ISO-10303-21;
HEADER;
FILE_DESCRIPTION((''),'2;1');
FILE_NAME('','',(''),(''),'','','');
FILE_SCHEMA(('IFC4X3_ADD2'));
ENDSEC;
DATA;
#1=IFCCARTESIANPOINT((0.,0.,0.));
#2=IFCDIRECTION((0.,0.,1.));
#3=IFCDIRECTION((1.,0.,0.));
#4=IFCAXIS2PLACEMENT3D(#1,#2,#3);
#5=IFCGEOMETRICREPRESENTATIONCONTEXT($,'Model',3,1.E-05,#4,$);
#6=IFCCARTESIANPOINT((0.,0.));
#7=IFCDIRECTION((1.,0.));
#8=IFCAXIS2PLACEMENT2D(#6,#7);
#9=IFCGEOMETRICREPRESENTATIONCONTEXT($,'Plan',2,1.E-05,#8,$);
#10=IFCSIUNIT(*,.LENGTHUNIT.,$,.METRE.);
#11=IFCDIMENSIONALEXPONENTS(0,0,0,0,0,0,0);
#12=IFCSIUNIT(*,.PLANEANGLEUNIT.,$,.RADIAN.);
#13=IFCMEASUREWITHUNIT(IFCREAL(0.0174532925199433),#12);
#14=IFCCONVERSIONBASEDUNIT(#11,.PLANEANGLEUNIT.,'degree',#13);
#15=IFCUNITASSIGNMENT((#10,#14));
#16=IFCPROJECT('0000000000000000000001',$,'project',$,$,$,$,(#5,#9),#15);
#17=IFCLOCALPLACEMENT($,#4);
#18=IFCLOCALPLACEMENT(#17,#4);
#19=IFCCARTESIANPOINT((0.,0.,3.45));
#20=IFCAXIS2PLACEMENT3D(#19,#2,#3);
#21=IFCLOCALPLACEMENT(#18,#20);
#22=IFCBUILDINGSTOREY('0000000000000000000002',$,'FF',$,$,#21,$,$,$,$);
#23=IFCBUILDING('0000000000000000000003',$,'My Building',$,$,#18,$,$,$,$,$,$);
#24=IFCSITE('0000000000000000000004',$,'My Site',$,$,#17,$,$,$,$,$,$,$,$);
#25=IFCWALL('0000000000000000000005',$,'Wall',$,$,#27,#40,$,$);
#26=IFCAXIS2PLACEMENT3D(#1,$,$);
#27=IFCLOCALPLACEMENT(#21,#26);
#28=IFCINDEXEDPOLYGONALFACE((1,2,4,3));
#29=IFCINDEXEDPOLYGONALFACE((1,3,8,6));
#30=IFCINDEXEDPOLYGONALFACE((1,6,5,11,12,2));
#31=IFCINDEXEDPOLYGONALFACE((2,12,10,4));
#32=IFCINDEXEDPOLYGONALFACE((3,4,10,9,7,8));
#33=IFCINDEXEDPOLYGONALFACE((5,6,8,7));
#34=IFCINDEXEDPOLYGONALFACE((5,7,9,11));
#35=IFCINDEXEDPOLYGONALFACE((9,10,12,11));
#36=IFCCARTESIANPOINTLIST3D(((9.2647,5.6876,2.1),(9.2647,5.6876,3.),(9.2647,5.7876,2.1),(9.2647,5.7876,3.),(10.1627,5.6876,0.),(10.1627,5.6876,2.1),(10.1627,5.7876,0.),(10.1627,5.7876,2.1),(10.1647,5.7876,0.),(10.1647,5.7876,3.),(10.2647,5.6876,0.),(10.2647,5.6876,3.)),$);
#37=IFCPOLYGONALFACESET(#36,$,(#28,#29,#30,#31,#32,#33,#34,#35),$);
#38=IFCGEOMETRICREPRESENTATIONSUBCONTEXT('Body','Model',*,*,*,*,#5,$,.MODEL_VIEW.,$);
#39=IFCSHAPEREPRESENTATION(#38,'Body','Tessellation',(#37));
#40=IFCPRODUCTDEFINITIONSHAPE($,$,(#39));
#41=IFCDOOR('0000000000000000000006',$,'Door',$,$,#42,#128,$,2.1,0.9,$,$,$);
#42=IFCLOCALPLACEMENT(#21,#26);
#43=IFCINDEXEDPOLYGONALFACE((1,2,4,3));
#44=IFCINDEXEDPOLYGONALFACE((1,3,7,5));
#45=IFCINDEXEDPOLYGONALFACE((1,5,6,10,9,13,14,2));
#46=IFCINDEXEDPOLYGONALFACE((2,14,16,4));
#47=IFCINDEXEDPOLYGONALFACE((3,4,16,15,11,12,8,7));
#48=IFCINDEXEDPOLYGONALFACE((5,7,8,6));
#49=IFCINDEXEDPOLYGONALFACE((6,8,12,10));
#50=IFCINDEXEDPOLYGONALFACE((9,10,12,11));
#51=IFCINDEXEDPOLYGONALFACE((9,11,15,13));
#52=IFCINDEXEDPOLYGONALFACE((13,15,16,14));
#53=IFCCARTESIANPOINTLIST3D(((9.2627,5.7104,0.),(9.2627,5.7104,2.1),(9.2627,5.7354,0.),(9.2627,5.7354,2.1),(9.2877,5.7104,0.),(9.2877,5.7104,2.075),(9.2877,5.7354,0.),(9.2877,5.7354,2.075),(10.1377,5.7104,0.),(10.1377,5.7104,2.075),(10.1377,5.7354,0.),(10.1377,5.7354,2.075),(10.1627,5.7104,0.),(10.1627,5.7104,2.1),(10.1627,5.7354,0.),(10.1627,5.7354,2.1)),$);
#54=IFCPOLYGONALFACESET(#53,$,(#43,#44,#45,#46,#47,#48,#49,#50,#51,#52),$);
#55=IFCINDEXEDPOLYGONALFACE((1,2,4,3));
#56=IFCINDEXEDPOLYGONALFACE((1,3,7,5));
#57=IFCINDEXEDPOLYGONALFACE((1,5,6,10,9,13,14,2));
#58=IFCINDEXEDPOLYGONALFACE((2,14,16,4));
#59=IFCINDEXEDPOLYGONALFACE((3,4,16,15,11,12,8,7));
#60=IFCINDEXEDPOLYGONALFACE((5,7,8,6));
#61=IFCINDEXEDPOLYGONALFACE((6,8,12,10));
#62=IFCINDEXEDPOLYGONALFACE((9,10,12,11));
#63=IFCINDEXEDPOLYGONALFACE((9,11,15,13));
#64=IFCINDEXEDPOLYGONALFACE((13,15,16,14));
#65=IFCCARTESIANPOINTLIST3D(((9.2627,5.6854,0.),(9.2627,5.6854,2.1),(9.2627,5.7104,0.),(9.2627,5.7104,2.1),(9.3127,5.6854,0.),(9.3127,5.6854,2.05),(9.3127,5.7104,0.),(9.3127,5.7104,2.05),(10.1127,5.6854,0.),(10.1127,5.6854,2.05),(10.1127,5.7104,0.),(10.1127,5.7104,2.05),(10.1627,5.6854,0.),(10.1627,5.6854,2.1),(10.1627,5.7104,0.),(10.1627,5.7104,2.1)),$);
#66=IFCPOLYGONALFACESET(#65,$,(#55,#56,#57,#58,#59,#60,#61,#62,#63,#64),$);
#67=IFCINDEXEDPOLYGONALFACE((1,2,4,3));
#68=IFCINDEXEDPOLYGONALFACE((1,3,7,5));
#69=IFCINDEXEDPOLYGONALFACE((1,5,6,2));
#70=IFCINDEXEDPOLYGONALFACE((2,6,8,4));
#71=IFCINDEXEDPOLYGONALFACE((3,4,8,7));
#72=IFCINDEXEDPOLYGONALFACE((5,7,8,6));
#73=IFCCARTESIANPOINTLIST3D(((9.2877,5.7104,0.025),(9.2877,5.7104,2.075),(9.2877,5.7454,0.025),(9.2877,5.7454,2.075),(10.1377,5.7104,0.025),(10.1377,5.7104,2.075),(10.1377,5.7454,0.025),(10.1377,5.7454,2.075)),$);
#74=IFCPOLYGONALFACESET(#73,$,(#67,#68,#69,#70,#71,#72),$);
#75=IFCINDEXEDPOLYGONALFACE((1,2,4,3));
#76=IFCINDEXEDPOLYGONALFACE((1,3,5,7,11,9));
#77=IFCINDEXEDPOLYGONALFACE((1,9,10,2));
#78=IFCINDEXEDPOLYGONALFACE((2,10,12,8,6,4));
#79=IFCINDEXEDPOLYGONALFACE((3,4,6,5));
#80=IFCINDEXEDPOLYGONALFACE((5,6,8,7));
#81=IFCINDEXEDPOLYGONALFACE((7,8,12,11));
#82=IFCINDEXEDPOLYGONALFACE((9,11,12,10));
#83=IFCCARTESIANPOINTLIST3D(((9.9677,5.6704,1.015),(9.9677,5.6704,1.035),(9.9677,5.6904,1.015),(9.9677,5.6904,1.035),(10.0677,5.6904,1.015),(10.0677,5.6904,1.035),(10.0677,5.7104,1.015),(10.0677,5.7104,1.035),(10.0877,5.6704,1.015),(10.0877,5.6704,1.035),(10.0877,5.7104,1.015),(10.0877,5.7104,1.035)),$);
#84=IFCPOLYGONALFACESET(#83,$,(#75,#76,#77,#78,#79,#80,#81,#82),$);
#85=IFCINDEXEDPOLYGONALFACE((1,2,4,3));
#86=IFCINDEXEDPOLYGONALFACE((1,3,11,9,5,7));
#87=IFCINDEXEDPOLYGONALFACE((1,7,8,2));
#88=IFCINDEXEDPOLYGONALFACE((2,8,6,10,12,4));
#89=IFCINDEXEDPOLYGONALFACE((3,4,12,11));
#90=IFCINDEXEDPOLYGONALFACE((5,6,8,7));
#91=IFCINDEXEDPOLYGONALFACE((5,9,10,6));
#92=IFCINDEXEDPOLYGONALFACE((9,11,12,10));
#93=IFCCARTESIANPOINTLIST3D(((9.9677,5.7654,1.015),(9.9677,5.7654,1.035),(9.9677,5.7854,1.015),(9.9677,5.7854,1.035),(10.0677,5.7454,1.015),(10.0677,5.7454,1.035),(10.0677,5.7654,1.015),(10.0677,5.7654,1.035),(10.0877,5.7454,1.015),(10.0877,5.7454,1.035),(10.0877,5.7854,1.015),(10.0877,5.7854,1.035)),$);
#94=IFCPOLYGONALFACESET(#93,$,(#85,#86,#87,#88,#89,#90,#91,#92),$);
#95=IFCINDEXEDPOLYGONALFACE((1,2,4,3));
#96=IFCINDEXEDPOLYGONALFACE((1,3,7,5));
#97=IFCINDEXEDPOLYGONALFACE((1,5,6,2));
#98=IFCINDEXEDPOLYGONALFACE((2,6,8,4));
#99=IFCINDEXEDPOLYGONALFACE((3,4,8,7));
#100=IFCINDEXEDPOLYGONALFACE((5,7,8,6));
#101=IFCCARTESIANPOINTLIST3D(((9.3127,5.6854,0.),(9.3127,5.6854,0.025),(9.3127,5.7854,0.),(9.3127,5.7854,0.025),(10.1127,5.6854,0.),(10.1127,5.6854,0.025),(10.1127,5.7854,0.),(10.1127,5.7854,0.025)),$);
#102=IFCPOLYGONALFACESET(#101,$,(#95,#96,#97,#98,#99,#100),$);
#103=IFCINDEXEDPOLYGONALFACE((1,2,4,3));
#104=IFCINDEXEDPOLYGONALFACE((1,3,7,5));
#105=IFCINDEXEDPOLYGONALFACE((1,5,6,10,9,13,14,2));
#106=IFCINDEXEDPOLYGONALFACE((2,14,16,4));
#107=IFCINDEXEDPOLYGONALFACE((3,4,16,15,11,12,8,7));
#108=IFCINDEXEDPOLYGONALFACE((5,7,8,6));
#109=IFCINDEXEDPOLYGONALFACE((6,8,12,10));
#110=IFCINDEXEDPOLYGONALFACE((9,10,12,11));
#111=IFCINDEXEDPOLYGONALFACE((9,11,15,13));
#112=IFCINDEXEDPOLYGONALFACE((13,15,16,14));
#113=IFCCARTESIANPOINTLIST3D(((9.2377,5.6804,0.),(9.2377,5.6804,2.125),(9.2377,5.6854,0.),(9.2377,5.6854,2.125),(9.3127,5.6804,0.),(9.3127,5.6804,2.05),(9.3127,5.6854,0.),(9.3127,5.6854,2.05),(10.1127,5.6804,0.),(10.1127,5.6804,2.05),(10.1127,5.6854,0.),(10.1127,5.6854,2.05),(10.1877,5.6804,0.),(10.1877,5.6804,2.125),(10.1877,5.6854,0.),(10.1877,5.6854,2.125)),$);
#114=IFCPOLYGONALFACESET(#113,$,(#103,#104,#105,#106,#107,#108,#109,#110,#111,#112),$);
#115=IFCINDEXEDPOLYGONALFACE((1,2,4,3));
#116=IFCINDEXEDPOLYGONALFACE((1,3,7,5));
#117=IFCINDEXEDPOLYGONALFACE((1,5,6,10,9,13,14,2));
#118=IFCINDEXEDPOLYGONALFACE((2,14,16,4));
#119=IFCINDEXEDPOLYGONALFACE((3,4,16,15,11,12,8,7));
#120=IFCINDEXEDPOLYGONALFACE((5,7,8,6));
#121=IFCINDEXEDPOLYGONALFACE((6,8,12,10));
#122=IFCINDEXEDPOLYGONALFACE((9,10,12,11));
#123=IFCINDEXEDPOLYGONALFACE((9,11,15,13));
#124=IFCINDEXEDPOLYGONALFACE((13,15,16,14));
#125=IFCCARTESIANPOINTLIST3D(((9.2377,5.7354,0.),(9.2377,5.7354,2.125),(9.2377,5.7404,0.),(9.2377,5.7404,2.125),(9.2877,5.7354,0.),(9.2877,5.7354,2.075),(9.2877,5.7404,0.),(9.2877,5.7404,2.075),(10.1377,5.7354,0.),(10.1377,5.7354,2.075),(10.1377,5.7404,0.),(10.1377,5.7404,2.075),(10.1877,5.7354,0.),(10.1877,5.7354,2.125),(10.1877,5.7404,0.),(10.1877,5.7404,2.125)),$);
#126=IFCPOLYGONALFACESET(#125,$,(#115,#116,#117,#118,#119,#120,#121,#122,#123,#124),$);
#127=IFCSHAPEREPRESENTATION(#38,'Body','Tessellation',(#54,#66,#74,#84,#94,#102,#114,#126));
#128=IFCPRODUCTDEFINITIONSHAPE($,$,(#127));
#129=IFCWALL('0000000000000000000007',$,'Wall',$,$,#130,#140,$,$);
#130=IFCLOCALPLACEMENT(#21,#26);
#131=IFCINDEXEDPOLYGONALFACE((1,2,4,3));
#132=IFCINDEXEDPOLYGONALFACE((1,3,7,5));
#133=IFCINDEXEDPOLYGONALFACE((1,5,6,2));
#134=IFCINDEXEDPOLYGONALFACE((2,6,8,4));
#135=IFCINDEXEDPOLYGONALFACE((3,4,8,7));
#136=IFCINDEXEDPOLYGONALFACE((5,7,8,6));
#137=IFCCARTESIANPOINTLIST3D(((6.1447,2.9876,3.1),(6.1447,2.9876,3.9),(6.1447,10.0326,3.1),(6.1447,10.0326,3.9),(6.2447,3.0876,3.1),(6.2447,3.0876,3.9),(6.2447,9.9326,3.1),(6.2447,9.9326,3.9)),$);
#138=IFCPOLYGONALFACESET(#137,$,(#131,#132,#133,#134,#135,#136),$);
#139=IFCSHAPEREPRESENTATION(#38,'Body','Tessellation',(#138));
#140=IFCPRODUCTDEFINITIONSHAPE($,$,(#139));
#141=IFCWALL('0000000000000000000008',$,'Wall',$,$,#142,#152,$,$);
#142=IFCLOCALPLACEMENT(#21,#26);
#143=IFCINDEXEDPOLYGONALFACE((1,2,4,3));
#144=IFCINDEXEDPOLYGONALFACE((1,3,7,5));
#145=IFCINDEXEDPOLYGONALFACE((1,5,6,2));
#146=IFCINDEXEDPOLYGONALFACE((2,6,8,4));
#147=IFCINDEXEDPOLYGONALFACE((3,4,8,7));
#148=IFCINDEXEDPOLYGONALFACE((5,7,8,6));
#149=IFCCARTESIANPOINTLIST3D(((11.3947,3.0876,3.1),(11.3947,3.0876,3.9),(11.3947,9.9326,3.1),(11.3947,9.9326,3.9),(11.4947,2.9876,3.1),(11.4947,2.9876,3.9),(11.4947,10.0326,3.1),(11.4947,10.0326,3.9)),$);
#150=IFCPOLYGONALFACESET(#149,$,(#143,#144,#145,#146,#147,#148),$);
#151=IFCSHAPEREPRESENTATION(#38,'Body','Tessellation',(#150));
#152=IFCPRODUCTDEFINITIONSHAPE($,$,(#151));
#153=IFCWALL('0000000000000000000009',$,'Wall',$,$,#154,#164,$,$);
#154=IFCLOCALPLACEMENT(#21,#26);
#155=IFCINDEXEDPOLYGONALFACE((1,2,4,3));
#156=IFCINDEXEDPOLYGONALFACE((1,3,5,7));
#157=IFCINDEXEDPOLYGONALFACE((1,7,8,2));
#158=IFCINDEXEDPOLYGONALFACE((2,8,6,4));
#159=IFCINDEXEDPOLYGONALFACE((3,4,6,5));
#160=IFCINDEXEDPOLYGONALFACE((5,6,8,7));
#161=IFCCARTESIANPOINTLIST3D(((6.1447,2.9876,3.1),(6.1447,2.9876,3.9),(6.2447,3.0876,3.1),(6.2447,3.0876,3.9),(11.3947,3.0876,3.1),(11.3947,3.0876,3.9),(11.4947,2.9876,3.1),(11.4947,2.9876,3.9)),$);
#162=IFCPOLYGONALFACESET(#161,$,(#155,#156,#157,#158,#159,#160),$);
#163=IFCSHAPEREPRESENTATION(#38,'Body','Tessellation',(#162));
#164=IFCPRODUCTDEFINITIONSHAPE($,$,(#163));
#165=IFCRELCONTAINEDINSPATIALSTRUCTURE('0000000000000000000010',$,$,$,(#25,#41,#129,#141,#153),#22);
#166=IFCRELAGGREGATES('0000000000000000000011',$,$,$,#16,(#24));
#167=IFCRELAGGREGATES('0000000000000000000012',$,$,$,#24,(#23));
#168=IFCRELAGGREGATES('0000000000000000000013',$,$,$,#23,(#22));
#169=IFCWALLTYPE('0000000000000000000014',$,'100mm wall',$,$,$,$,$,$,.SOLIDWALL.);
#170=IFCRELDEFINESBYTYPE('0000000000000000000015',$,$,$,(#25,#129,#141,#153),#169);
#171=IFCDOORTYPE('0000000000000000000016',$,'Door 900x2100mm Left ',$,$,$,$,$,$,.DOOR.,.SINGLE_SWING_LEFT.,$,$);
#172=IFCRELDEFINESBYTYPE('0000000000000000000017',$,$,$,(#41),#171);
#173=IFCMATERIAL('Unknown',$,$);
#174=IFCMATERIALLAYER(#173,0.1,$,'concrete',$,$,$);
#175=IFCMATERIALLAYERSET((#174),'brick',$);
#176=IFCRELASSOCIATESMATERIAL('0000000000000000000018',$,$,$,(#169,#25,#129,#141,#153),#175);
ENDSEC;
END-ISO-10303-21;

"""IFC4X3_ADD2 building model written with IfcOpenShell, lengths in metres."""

from ifc_helpers import new_model, entity, si_unit, converted_unit, frame, origin_with_axes, origin_2d_with_axis, place, context, subcontext, project, spatial, line, indexed_curve, outline, extrude, shape, source, transform, mapped, material, layer, layer_set, layer_usage, type_object, type_shapes, element, fill, save


model = new_model("IFC4X3_ADD2")

# Units and contexts
model_context = context("Model", 3, precision=1e-05, world=origin_with_axes())
plan_context = context("Plan", 2, precision=1e-05, world=origin_2d_with_axis())
body_context_1 = subcontext(model_context, "Body", "Model", "MODEL_VIEW")
body_context_2 = subcontext(plan_context, "Body", "Plan", "PLAN_VIEW")
ifc_project = project(units=[si_unit("LENGTHUNIT", "METRE"), converted_unit("PLANEANGLEUNIT", "degree", entity("IfcReal", 0.0174532925199433), si_unit("PLANEANGLEUNIT", "RADIAN"), dimensions=[0, 0, 0, 0, 0, 0, 0])], contexts=[model_context, plan_context])

# Site, building, storey
site_placement = place(None, origin_with_axes())
site = spatial("IfcSite", under=ifc_project, at=site_placement, Name="My Site")
building_placement = place(site_placement, origin_with_axes())
building = spatial("IfcBuilding", under=site, at=building_placement, Name="My Building")
storey_placement = place(building_placement, frame((0.0, 0.0, 3.45), z_axis=(0.0, 0.0, 1.0), x_axis=(1.0, 0.0, 0.0)))
storey = spatial("IfcBuildingStorey", under=building, at=storey_placement, Name="FF")

# Shared definitions
ifc_material = material(Name="Unknown")

# Shared definitions
ifc_layer_1 = layer(ifc_material, 0.1, Name="concrete")
ifc_layer_set_1 = layer_set([ifc_layer_1], Name="brick")
wall_type_1 = type_object("IfcWallType", Name="100mm wall", PredefinedType="SOLIDWALL", material=ifc_layer_set_1)

# Shared definitions
shared_shape_1 = source(origin_with_axes(), body_context_1, "Body", "SweptSolid", [
    extrude(outline(indexed_curve([(0.0, 0.0), (0.9, 0.0), (0.9, 2.1), (0.0, 2.1)], segments=[line(1, 2, 3, 4, 1)])), frame((0.0, -0.6, 0.0), z_axis=(0.0, -1.0, 0.0), x_axis=(1.0, 0.0, 0.0)), (0.0, 0.0, -1.0), 1.2),
])
door_type_1 = type_object("IfcDoorType", Name="Door 900x2100mm Left ", OperationType="SINGLE_SWING_LEFT", PredefinedType="DOOR")
shared_shape_2 = source(origin_with_axes(), body_context_1, "Body", "SweptSolid", [
    extrude(outline(indexed_curve([(0.0, 0.0), (0.0, 2.1), (0.9, 2.1), (0.9, 0.0), (0.875, 0.0), (0.875, 2.075), (0.025, 2.075), (0.025, 0.0)], segments=[line(1, 2, 3, 4, 5, 6, 7, 8, 1)])), frame((0.0, 0.025, 0.0), z_axis=(0.0, -1.0, 0.0), x_axis=(1.0, 0.0, 0.0)), (0.0, 0.0, -1.0), 0.025),
    extrude(outline(indexed_curve([(0.0, 0.0), (0.0, 2.1), (0.9, 2.1), (0.9, 0.0), (0.85, 0.0), (0.85, 2.05), (0.05, 2.05), (0.05, 0.0)], segments=[line(1, 2, 3, 4, 5, 6, 7, 8, 1)])), frame((0.0, 0.0, 0.0), z_axis=(0.0, -1.0, 0.0), x_axis=(1.0, 0.0, 0.0)), (0.0, 0.0, -1.0), 0.025),
    extrude(outline(indexed_curve([(0.0, 0.0), (0.85, 0.0), (0.85, 0.035), (0.0, 0.035)], segments=[line(1, 2, 3, 4, 1)])), frame((0.025, 0.025, 0.025), z_axis=(0.0, 0.0, 1.0), x_axis=(1.0, 0.0, 0.0)), (0.0, 0.0, 1.0), 2.05),
    extrude(outline(indexed_curve([(0.0, 0.0), (0.0, -0.04), (-0.12, -0.04), (-0.12, -0.02), (-0.02, -0.02), (-0.02, 0.0)], segments=[line(1, 2, 3, 4, 5, 6, 1)])), frame((0.825, 0.025, 1.015), z_axis=(0.0, 0.0, 1.0), x_axis=(1.0, 0.0, 0.0)), (0.0, 0.0, 1.0), 0.02),
    extrude(outline(indexed_curve([(0.0, 0.0), (0.0, 0.04), (-0.12, 0.04), (-0.12, 0.02), (-0.02, 0.02), (-0.02, 0.0)], segments=[line(1, 2, 3, 4, 5, 6, 1)])), frame((0.825, 0.06, 1.015), z_axis=(0.0, 0.0, 1.0), x_axis=(1.0, 0.0, 0.0)), (0.0, 0.0, 1.0), 0.02),
    extrude(outline(indexed_curve([(0.0, 0.0), (0.8, 0.0), (0.8, 0.1), (0.0, 0.1)], segments=[line(1, 2, 3, 4, 1)])), frame((0.05, 0.0, 0.0), z_axis=(0.0, 0.0, 1.0), x_axis=(1.0, 0.0, 0.0)), (0.0, 0.0, 1.0), 0.025),
    extrude(outline(indexed_curve([(0.0, 0.0), (0.0, 2.125), (0.95, 2.125), (0.95, 0.0), (0.875, 0.0), (0.875, 2.05), (0.075, 2.05), (0.075, 0.0)], segments=[line(1, 2, 3, 4, 5, 6, 7, 8, 1)])), frame((-0.025, -0.005, 0.0), z_axis=(0.0, -1.0, 0.0), x_axis=(1.0, 0.0, 0.0)), (0.0, 0.0, -1.0), 0.005),
    extrude(outline(indexed_curve([(0.0, 0.0), (0.0, 2.125), (0.95, 2.125), (0.95, 0.0), (0.9, 0.0), (0.9, 2.075), (0.05, 2.075), (0.05, 0.0)], segments=[line(1, 2, 3, 4, 5, 6, 7, 8, 1)])), frame((-0.025, 0.05, 0.0), z_axis=(0.0, -1.0, 0.0), x_axis=(1.0, 0.0, 0.0)), (0.0, 0.0, -1.0), 0.005),
])
shared_shape_3 = source(origin_with_axes(), body_context_2, "Body", "Curve2D", [
    entity("IfcIndexedPolyCurve", entity("IfcCartesianPointList2D", [[0.0, 0.0], [0.0, 0.05], [0.025, 0.05], [0.025, 0.025], [0.05, 0.025], [0.05, 0.0]]), [entity("IfcLineIndex", [1, 2, 3, 4, 5, 6, 1])]),
    entity("IfcIndexedPolyCurve", entity("IfcCartesianPointList2D", [[0.9, 0.0], [0.9, 0.05], [0.875, 0.05], [0.875, 0.025], [0.85, 0.025], [0.85, 0.0]]), [entity("IfcLineIndex", [1, 2, 3, 4, 5, 6, 1])]),
    entity("IfcTrimmedCurve", entity("IfcEllipse", entity("IfcAxis2Placement2D", entity("IfcCartesianPoint", [0.06, 0.05]), entity("IfcDirection", [1.0, 0.0])), 0.815, 0.85), [entity("IfcCartesianPoint", [0.875, 0.05])], [entity("IfcCartesianPoint", [0.06, 0.9])], True, "CARTESIAN"),
    entity("IfcIndexedPolyCurve", entity("IfcCartesianPointList2D", [[0.025, 0.05], [0.06, 0.05], [0.06, 0.9], [0.025, 0.9]]), [entity("IfcLineIndex", [1, 2, 3, 4, 1])]),
])
type_shapes(door_type_1, [shared_shape_2, shared_shape_3])

# Wall, opening, door
ifc_layer_usage_1 = layer_usage(ifc_layer_set_1, "AXIS2", "POSITIVE", 0.0)
wall_1_placement = place(storey_placement, frame((10.2647, 5.7876, 0.0), z_axis=(0.0, 0.0, 1.0), x_axis=(-1.0, 0.0, 0.0)))
wall_1 = element("IfcWall", 1, at=wall_1_placement, inside=storey, type_object=wall_type_1, material=ifc_layer_usage_1, Name="Wall", context=body_context_1, shape_type="SweptSolid", body=[
    extrude(outline(indexed_curve([(0.1, 0.0), (0.0, 0.1), (1.0, 0.1), (1.0, 0.0)], segments=[line(1, 2, 3, 4, 1)])), origin_with_axes(), (0.0, 0.0, 1.0), 3.0),
])
opening_1_placement = place(wall_1_placement, frame((1.002, 0.1022, 0.0), z_axis=(0.0, 0.0, 1.0), x_axis=(-1.0, 0.0, 0.0)))
opening_1 = element("IfcOpeningElement", 2, at=opening_1_placement, cuts=wall_1, PredefinedType="OPENING", context=body_context_1, shape_type="MappedRepresentation", body=[
    mapped(shared_shape_1, transform((0.0, 0.0, 0.0), x_axis=(1.0, 0.0, 0.0), y_axis=(0.0, 1.0, 0.0), z_axis=(0.0, 0.0, 1.0), scale=1.0)),
])
door_1_placement = place(opening_1_placement, frame((0.0, 0.0, 0.0), z_axis=(0.0, 0.0, 1.0), x_axis=(1.0, 0.0, 0.0)))
door_1 = element("IfcDoor", 3, at=door_1_placement, inside=storey, type_object=door_type_1, Name="Door", OverallHeight=2.1, OverallWidth=0.9, shapes=[
    shape(body_context_1, "Body", "MappedRepresentation", [mapped(shared_shape_2, transform((0.0, 0.0, 0.0), x_axis=(1.0, 0.0, 0.0), y_axis=(0.0, 1.0, 0.0), z_axis=(0.0, 0.0, 1.0), scale=1.0))]),
    shape(body_context_2, "Body", "MappedRepresentation", [mapped(shared_shape_3, transform((0.0, 0.0, 0.0), x_axis=(1.0, 0.0, 0.0), y_axis=(0.0, 1.0, 0.0), z_axis=(0.0, 0.0, 1.0), scale=1.0))]),
])
fill(opening_1, door_1)

# Walls
ifc_layer_usage_2 = layer_usage(ifc_layer_set_1, "AXIS2", "POSITIVE", 0.0)
wall_2_placement = place(storey_placement, frame((6.2447, 3.0876, 3.1), z_axis=(0.0, 0.0, 1.0), x_axis=(0.0, 1.0, 0.0)))
element("IfcWall", 4, at=wall_2_placement, inside=storey, type_object=wall_type_1, material=ifc_layer_usage_2, Name="Wall", context=body_context_1, shape_type="SweptSolid", body=[
    extrude(outline(indexed_curve([(0.0, 0.0), (-0.1, 0.1), (6.945, 0.1), (6.845, 0.0)], segments=[line(1, 2, 3, 4, 1)])), origin_with_axes(), (0.0, 0.0, 1.0), 0.8),
])
ifc_layer_usage_3 = layer_usage(ifc_layer_set_1, "AXIS2", "POSITIVE", 0.0)
wall_3_placement = place(storey_placement, frame((11.4947, 3.0876, 3.1), z_axis=(0.0, 0.0, 1.0), x_axis=(0.0, 1.0, 0.0)))
element("IfcWall", 5, at=wall_3_placement, inside=storey, type_object=wall_type_1, material=ifc_layer_usage_3, Name="Wall", context=body_context_1, shape_type="SweptSolid", body=[
    extrude(outline(indexed_curve([(-0.1, 0.0), (0.0, 0.1), (6.845, 0.1), (6.945, 0.0)], segments=[line(1, 2, 3, 4, 1)])), origin_with_axes(), (0.0, 0.0, 1.0), 0.8),
])
ifc_layer_usage_4 = layer_usage(ifc_layer_set_1, "AXIS2", "POSITIVE", 0.0)
wall_4_placement = place(storey_placement, frame((11.4947, 3.0876, 3.1), z_axis=(0.0, 0.0, 1.0), x_axis=(-1.0, 0.0, 0.0)))
element("IfcWall", 6, at=wall_4_placement, inside=storey, type_object=wall_type_1, material=ifc_layer_usage_4, Name="Wall", context=body_context_1, shape_type="SweptSolid", body=[
    extrude(outline(indexed_curve([(0.1, 0.0), (0.0, 0.1), (5.35, 0.1), (5.25, 0.0)], segments=[line(1, 2, 3, 4, 1)])), origin_with_axes(), (0.0, 0.0, 1.0), 0.8),
])

save(model, "model.ifc")
